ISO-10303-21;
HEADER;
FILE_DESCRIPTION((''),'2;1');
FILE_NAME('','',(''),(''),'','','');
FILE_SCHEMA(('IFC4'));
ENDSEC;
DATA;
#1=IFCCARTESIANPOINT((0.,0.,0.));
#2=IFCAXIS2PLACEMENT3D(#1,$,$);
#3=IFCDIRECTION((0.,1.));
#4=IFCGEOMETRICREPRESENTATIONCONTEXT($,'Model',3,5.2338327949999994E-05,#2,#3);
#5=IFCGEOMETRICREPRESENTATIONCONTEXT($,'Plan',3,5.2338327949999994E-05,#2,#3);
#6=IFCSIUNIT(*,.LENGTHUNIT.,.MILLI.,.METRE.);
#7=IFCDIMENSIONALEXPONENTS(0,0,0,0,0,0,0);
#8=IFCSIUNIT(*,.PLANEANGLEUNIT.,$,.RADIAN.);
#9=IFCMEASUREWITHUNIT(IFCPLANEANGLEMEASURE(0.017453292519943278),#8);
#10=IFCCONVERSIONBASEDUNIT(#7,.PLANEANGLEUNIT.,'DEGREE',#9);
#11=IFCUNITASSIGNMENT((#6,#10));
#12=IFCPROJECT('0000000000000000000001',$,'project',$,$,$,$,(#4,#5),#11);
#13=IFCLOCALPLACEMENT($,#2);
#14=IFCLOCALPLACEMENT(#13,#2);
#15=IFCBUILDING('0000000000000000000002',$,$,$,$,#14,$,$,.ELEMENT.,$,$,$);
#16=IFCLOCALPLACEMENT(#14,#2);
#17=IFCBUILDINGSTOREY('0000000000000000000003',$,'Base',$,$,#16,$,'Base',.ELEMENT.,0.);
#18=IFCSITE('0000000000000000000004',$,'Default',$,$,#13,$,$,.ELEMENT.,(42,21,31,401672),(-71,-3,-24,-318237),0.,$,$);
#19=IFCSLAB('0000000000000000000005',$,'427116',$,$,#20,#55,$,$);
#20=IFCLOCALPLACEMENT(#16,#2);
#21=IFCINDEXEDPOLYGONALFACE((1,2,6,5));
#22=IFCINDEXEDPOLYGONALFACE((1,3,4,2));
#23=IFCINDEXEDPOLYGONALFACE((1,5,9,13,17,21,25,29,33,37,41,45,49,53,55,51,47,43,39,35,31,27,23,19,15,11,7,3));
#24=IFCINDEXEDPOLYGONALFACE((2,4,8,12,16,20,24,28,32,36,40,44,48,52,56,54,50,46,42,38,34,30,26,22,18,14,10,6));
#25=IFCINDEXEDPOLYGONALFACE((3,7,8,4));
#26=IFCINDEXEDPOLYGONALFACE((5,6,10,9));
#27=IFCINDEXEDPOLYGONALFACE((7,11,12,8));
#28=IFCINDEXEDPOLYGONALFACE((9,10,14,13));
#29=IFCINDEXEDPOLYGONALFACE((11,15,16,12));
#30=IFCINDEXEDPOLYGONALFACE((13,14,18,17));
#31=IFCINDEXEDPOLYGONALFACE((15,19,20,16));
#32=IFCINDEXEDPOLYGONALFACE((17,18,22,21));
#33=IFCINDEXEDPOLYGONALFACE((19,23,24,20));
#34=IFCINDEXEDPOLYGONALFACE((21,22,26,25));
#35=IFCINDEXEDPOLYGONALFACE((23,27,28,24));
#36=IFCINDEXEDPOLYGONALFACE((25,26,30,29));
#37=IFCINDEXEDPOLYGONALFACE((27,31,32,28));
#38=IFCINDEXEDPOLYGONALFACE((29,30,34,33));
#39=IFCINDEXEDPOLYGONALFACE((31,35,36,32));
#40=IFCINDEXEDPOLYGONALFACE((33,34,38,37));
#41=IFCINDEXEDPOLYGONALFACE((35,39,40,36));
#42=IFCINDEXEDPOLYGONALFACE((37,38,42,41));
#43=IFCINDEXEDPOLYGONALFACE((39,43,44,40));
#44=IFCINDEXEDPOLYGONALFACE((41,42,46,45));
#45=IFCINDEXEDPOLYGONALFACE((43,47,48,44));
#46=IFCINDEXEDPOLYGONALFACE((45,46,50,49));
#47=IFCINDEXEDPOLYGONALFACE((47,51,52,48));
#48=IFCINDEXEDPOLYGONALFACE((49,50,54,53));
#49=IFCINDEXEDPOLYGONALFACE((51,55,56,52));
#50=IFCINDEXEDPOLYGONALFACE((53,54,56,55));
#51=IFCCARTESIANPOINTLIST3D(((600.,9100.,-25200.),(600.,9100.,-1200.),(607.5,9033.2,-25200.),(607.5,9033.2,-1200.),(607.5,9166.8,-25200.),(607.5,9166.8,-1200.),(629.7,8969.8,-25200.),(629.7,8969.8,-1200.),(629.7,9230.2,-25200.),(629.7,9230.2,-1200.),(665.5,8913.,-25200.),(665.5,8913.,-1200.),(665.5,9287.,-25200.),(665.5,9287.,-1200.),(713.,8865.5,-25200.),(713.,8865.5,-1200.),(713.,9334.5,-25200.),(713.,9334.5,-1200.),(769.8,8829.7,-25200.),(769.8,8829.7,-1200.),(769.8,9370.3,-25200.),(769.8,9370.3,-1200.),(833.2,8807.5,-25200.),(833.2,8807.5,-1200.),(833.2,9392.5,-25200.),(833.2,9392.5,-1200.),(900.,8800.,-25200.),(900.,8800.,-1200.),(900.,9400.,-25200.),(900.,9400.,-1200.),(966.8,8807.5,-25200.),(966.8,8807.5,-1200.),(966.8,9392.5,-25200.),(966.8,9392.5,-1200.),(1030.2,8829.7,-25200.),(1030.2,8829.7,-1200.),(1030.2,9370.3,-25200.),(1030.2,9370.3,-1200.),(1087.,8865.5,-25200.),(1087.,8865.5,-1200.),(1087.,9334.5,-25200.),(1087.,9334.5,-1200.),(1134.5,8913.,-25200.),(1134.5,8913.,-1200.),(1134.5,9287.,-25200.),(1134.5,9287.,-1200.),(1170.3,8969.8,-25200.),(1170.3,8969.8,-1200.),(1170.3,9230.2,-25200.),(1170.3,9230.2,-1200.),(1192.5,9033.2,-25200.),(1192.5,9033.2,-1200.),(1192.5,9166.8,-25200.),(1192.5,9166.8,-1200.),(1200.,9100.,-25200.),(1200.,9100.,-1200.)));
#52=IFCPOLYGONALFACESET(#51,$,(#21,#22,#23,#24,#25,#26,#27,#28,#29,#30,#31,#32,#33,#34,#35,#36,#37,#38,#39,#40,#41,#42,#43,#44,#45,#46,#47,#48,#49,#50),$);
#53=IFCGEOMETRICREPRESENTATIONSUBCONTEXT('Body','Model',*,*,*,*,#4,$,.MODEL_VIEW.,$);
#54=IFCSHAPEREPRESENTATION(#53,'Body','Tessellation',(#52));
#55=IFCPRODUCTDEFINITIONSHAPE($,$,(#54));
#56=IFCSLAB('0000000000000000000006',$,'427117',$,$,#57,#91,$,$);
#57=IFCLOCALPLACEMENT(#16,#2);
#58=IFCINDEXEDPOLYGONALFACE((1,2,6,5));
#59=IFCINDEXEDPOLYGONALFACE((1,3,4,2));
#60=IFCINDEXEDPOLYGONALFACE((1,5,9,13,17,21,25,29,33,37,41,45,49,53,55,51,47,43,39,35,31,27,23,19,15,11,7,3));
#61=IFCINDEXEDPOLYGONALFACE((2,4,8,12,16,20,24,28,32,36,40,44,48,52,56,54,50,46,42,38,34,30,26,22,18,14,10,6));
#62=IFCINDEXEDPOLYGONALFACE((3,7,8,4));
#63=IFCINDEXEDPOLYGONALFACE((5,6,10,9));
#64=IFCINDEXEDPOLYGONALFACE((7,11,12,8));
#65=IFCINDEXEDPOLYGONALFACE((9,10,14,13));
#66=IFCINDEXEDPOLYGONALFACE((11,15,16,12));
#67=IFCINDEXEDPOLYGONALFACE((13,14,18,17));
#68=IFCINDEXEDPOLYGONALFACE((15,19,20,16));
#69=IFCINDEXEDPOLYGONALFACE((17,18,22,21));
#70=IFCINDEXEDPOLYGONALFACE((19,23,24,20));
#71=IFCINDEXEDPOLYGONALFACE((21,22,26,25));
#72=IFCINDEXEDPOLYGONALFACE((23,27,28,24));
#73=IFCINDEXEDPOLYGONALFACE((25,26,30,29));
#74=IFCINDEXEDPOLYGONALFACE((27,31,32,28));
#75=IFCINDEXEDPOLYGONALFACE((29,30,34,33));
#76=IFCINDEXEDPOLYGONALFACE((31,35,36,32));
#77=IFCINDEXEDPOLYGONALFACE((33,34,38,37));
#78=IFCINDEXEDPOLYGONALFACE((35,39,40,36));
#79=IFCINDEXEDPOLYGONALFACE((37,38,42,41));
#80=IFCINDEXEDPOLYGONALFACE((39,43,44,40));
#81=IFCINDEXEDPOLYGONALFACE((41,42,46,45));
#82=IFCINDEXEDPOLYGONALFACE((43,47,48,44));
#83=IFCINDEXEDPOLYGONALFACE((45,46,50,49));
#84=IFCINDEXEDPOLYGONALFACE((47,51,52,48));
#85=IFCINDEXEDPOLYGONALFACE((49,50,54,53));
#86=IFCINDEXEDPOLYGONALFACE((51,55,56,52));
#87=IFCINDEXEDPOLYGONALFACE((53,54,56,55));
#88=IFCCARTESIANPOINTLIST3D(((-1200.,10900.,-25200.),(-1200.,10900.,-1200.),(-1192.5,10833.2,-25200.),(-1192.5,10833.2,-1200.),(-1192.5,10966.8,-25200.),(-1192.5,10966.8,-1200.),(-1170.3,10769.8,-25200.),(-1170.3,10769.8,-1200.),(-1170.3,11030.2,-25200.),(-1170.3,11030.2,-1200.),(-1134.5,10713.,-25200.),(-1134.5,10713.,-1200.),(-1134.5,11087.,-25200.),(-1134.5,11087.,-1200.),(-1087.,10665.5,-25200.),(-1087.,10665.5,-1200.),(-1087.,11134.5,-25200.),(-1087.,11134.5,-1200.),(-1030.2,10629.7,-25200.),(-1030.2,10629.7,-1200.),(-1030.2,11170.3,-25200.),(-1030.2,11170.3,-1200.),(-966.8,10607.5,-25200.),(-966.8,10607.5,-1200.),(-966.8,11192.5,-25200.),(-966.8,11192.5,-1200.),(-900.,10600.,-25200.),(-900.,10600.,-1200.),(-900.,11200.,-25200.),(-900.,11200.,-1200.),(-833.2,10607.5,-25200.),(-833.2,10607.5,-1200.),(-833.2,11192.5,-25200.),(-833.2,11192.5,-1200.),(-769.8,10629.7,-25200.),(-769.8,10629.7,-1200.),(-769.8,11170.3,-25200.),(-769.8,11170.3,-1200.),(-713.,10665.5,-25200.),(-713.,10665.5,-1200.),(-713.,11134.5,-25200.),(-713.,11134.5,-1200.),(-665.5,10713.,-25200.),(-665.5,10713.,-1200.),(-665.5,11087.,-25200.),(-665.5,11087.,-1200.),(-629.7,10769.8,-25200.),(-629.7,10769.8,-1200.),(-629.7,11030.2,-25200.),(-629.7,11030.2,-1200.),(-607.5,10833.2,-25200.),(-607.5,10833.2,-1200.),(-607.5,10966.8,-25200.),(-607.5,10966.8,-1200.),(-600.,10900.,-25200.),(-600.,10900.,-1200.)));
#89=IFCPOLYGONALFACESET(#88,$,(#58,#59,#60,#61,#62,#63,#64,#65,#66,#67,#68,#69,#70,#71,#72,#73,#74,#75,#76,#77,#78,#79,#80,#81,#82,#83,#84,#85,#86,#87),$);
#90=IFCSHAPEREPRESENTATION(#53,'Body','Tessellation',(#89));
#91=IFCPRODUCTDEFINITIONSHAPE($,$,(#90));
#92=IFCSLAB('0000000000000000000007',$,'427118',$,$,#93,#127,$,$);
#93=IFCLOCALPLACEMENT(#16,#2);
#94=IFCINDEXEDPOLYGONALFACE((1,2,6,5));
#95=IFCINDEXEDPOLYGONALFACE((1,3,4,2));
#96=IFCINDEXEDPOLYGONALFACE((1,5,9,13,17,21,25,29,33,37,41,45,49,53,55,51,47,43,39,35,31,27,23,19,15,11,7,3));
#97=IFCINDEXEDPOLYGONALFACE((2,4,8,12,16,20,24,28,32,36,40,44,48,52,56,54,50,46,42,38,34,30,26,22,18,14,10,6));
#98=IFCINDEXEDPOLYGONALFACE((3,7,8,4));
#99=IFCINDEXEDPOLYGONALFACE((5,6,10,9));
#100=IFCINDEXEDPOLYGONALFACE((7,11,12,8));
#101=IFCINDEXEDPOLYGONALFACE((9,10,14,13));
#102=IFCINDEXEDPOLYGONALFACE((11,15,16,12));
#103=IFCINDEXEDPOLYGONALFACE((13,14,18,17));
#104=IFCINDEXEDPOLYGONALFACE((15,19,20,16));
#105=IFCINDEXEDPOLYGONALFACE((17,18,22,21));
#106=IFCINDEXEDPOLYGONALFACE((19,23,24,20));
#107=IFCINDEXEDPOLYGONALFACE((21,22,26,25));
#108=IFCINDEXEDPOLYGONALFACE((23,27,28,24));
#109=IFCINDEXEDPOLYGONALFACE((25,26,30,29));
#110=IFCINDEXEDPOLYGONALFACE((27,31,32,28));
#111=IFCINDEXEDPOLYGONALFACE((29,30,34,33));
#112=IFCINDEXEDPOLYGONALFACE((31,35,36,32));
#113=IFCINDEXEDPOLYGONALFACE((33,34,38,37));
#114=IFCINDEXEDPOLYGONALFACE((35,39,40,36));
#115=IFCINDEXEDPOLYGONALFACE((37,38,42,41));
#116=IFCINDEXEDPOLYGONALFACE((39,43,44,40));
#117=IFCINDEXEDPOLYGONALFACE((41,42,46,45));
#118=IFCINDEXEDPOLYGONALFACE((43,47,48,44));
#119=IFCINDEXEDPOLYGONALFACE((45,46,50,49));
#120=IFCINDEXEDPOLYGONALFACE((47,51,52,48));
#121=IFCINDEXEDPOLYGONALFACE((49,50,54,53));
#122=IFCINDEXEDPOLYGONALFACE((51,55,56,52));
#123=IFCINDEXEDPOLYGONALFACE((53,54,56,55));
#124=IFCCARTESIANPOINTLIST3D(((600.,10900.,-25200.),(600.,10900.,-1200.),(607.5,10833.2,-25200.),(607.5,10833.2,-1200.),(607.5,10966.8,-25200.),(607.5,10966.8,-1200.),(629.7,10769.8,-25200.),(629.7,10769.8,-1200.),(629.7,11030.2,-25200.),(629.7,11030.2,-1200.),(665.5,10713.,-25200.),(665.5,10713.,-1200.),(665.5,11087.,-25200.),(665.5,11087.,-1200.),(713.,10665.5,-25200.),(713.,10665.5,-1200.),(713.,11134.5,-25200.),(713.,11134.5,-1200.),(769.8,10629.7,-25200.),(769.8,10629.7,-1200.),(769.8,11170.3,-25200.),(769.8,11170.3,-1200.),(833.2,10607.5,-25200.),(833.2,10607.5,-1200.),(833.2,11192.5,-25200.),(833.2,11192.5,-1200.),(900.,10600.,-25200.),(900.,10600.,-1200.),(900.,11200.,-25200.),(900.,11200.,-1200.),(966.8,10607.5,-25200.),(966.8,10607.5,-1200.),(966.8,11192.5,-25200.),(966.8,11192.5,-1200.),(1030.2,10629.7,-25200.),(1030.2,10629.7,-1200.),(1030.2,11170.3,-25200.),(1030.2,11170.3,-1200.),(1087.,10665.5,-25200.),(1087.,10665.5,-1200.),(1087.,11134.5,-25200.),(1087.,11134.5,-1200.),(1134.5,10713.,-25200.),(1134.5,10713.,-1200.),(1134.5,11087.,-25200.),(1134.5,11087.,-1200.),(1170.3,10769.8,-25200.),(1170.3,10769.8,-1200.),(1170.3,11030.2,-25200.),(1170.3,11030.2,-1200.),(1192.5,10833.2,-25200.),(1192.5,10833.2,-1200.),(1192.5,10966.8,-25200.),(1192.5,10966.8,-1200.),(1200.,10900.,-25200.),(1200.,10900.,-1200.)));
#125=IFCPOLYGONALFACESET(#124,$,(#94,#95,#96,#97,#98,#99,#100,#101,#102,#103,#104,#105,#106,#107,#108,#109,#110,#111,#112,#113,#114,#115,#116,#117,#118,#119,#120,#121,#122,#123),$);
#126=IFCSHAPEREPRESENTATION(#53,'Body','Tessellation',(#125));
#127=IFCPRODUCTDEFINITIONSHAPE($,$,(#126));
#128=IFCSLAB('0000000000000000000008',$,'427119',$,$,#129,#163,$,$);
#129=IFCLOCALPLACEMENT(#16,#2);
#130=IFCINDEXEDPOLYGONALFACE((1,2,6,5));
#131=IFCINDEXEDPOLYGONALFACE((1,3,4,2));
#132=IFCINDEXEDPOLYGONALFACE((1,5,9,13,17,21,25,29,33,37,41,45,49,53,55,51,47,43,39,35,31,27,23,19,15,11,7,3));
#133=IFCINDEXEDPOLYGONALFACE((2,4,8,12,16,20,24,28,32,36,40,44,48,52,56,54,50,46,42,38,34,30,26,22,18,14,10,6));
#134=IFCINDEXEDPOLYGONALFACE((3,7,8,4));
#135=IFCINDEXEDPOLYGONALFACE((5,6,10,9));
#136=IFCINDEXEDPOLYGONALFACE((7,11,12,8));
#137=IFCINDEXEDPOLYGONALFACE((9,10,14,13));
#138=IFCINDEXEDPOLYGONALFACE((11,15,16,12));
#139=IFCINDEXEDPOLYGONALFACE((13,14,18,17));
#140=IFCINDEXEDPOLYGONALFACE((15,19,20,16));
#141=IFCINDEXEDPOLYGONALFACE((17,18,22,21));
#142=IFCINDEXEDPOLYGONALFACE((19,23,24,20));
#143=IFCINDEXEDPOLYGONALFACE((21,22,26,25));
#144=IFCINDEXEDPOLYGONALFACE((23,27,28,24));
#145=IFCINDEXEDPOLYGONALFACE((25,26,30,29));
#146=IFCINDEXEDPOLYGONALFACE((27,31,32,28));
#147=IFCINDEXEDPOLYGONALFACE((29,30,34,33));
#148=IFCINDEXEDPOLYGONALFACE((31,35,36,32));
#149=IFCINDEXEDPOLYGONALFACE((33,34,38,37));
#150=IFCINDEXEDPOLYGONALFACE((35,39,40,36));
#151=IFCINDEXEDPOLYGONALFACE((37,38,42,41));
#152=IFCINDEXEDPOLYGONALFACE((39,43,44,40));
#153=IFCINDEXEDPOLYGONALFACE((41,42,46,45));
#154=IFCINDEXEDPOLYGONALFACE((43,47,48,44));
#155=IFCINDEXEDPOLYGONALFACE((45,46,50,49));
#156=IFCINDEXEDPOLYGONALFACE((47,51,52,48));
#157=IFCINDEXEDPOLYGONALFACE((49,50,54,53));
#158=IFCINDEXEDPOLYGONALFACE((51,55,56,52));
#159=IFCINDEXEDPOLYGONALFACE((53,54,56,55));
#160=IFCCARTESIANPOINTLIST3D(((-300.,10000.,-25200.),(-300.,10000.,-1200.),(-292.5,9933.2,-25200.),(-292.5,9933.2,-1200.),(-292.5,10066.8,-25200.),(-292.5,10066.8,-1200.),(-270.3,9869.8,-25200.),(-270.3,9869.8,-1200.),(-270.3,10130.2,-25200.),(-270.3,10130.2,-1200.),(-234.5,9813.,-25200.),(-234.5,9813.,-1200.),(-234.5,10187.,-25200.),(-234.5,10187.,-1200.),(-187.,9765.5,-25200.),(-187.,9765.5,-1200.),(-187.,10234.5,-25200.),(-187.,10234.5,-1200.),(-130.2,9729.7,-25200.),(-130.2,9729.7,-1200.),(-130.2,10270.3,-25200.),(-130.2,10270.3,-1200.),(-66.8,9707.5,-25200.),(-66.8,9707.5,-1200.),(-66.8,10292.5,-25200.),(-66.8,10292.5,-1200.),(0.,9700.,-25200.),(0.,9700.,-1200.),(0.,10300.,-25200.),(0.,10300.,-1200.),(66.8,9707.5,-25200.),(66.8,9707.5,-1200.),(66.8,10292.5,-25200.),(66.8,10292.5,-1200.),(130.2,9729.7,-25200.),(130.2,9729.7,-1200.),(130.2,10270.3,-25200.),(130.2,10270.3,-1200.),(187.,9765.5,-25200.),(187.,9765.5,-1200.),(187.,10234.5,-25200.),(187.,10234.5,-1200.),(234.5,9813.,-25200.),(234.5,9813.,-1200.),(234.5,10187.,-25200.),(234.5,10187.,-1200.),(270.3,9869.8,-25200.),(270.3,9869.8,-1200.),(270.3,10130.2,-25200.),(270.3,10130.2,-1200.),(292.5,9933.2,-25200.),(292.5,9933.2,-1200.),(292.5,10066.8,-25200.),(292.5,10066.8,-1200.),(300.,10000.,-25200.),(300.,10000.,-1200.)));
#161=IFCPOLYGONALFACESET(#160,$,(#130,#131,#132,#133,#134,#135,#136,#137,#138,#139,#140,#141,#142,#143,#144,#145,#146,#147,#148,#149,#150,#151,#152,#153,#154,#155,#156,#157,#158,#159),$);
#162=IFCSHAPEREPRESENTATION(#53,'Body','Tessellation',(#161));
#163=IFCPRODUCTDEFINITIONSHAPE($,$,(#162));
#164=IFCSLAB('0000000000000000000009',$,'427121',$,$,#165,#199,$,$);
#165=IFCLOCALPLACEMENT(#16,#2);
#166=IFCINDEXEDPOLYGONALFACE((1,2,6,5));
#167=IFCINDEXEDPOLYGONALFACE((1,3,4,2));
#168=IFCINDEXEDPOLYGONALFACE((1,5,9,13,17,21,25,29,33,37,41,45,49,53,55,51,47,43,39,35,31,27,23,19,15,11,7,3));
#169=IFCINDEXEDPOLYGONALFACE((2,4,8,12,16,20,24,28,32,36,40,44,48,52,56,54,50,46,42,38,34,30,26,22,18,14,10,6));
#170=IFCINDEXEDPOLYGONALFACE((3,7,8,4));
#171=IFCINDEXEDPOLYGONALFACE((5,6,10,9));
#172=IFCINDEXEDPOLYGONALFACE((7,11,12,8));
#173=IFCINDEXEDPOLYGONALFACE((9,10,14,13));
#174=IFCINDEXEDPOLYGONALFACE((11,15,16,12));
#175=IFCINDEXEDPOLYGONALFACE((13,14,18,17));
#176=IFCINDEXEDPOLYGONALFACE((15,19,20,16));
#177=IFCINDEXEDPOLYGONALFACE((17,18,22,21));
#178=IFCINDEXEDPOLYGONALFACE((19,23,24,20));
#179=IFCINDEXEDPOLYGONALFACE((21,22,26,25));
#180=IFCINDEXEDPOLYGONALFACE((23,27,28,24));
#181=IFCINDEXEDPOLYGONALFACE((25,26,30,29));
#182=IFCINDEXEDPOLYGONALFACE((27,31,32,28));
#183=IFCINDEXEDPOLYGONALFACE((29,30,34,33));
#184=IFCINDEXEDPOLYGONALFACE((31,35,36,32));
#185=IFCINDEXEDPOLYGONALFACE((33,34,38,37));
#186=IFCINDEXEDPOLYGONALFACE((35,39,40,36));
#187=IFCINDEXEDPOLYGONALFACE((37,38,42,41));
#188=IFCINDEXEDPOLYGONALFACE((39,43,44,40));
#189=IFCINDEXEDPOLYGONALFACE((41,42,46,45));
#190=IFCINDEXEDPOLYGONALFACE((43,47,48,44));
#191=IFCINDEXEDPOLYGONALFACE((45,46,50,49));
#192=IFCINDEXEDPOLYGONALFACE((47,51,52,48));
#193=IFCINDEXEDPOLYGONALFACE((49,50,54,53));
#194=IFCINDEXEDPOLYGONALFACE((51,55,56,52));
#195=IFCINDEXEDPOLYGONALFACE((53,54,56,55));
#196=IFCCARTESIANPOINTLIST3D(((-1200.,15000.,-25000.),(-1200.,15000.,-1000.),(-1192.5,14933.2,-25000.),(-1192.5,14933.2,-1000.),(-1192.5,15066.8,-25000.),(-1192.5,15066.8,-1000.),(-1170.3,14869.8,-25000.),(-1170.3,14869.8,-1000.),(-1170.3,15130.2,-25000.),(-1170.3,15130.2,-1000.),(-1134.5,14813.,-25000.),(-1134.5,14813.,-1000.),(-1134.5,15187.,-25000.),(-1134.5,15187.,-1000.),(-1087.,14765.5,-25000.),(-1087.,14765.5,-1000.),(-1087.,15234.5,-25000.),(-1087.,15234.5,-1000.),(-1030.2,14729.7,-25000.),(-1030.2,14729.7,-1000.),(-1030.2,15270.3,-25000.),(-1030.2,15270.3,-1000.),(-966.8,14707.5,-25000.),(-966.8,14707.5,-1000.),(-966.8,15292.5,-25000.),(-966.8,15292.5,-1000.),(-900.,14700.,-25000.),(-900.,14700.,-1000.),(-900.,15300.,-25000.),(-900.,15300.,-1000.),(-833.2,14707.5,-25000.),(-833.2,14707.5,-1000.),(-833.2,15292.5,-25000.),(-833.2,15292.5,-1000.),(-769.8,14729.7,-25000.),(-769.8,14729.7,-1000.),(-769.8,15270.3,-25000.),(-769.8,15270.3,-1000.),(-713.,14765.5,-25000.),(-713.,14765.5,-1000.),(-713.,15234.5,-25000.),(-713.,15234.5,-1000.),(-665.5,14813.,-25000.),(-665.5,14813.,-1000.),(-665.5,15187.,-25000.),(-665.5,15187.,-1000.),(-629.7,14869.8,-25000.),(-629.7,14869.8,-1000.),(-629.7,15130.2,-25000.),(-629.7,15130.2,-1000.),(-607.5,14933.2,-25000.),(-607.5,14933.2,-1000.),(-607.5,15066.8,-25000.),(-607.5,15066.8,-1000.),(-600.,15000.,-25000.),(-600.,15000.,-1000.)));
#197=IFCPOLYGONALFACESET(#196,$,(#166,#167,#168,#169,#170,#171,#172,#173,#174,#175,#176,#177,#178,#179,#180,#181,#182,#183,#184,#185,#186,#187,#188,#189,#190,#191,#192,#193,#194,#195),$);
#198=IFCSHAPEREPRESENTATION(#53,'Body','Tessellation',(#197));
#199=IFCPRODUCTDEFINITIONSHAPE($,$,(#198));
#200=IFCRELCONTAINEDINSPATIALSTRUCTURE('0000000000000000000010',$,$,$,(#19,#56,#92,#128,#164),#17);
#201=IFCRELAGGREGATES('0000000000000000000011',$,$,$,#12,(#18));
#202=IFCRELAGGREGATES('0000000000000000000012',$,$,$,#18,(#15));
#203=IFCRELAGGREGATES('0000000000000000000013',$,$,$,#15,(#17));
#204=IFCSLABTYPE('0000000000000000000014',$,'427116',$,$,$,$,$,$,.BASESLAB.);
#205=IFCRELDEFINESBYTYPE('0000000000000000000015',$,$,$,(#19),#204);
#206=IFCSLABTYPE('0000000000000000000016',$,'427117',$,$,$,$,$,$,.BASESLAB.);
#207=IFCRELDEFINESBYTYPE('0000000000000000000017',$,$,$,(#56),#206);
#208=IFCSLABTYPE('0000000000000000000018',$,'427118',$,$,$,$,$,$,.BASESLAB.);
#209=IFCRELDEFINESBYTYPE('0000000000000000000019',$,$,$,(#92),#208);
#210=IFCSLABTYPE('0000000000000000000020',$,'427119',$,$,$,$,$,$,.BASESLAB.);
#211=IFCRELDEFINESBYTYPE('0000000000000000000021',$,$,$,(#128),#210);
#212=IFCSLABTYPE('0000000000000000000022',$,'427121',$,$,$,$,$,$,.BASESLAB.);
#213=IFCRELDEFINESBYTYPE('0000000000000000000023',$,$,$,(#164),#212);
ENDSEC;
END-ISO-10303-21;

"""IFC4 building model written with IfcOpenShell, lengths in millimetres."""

from ifc_helpers import new_model, entity, si_unit, converted_unit, direction, frame, origin, place, context, subcontext, project, spatial, arc, indexed_curve, outline, extrude, type_object, element, save


model = new_model("IFC4")

# Units and contexts
model_context = context("Model", 3, precision=5.2338327949999994e-05, world=origin(), true_north=direction((0.0, 1.0)))
plan_context = context("Plan", 3, precision=5.2338327949999994e-05, world=origin(), true_north=direction((0.0, 1.0)))
body_context = subcontext(model_context, "Body", "Model", "MODEL_VIEW")
ifc_project = project(units=[si_unit("LENGTHUNIT", "METRE", prefix="MILLI"), converted_unit("PLANEANGLEUNIT", "DEGREE", entity("IfcPlaneAngleMeasure", 0.017453292519943278), si_unit("PLANEANGLEUNIT", "RADIAN"), dimensions=[0, 0, 0, 0, 0, 0, 0])], contexts=[model_context, plan_context])

# Site, building, storey
site_placement = place(None, origin())
site = spatial("IfcSite", under=ifc_project, at=site_placement, Name="Default", CompositionType="ELEMENT", RefLatitude=(42, 21, 31, 401672), RefLongitude=(-71, -3, -24, -318237), RefElevation=0.0)
building_placement = place(site_placement, origin())
building = spatial("IfcBuilding", under=site, at=building_placement, CompositionType="ELEMENT")
storey_placement = place(building_placement, origin())
storey = spatial("IfcBuildingStorey", under=building, at=storey_placement, Name="Base", LongName="Base", CompositionType="ELEMENT", Elevation=0.0)

# Slabs
slab_type_1 = type_object("IfcSlabType", Name="427116", PredefinedType="BASESLAB")
slab_1_placement = place(storey_placement, origin())
element("IfcSlab", 1, at=slab_1_placement, inside=storey, type_object=slab_type_1, Name="427116", context=body_context, shape_type="SweptSolid", body=[
    extrude(outline(indexed_curve([(300.0, 0.0), (0.0, 300.0), (-300.0, 0.0), (0.0, -300.0)], segments=[arc(1, 2, 3), arc(3, 4, 1)], self_intersect=False)), frame((900.0, 9100.0, -25200.0)), (0.0, 0.0, 1.0), 24000.0),
])
slab_type_2 = type_object("IfcSlabType", Name="427117", PredefinedType="BASESLAB")
slab_2_placement = place(storey_placement, origin())
element("IfcSlab", 2, at=slab_2_placement, inside=storey, type_object=slab_type_2, Name="427117", context=body_context, shape_type="SweptSolid", body=[
    extrude(outline(indexed_curve([(300.0, 0.0), (0.0, 300.0), (-300.0, 0.0), (0.0, -300.0)], segments=[arc(1, 2, 3), arc(3, 4, 1)], self_intersect=False)), frame((-900.0, 10900.0, -25200.0)), (0.0, 0.0, 1.0), 24000.0),
])
slab_type_3 = type_object("IfcSlabType", Name="427118", PredefinedType="BASESLAB")
slab_3_placement = place(storey_placement, origin())
element("IfcSlab", 3, at=slab_3_placement, inside=storey, type_object=slab_type_3, Name="427118", context=body_context, shape_type="SweptSolid", body=[
    extrude(outline(indexed_curve([(300.0, 0.0), (0.0, 300.0), (-300.0, 0.0), (0.0, -300.0)], segments=[arc(1, 2, 3), arc(3, 4, 1)], self_intersect=False)), frame((900.0, 10900.0, -25200.0)), (0.0, 0.0, 1.0), 24000.0),
])
slab_type_4 = type_object("IfcSlabType", Name="427119", PredefinedType="BASESLAB")
slab_4_placement = place(storey_placement, origin())
element("IfcSlab", 4, at=slab_4_placement, inside=storey, type_object=slab_type_4, Name="427119", context=body_context, shape_type="SweptSolid", body=[
    extrude(outline(indexed_curve([(300.0, 0.0), (0.0, 300.0), (-300.0, 0.0), (0.0, -300.0)], segments=[arc(1, 2, 3), arc(3, 4, 1)], self_intersect=False)), frame((0.0, 10000.0, -25200.0)), (0.0, 0.0, 1.0), 24000.0),
])
slab_type_5 = type_object("IfcSlabType", Name="427121", PredefinedType="BASESLAB")
slab_5_placement = place(storey_placement, origin())
element("IfcSlab", 5, at=slab_5_placement, inside=storey, type_object=slab_type_5, Name="427121", context=body_context, shape_type="SweptSolid", body=[
    extrude(outline(indexed_curve([(300.0, 0.0), (0.0, 300.0), (-300.0, 0.0), (0.0, -300.0)], segments=[arc(1, 2, 3), arc(3, 4, 1)], self_intersect=False)), frame((-900.0, 15000.0, -25000.0)), (0.0, 0.0, 1.0), 24000.0),
])

save(model, "model.ifc")
